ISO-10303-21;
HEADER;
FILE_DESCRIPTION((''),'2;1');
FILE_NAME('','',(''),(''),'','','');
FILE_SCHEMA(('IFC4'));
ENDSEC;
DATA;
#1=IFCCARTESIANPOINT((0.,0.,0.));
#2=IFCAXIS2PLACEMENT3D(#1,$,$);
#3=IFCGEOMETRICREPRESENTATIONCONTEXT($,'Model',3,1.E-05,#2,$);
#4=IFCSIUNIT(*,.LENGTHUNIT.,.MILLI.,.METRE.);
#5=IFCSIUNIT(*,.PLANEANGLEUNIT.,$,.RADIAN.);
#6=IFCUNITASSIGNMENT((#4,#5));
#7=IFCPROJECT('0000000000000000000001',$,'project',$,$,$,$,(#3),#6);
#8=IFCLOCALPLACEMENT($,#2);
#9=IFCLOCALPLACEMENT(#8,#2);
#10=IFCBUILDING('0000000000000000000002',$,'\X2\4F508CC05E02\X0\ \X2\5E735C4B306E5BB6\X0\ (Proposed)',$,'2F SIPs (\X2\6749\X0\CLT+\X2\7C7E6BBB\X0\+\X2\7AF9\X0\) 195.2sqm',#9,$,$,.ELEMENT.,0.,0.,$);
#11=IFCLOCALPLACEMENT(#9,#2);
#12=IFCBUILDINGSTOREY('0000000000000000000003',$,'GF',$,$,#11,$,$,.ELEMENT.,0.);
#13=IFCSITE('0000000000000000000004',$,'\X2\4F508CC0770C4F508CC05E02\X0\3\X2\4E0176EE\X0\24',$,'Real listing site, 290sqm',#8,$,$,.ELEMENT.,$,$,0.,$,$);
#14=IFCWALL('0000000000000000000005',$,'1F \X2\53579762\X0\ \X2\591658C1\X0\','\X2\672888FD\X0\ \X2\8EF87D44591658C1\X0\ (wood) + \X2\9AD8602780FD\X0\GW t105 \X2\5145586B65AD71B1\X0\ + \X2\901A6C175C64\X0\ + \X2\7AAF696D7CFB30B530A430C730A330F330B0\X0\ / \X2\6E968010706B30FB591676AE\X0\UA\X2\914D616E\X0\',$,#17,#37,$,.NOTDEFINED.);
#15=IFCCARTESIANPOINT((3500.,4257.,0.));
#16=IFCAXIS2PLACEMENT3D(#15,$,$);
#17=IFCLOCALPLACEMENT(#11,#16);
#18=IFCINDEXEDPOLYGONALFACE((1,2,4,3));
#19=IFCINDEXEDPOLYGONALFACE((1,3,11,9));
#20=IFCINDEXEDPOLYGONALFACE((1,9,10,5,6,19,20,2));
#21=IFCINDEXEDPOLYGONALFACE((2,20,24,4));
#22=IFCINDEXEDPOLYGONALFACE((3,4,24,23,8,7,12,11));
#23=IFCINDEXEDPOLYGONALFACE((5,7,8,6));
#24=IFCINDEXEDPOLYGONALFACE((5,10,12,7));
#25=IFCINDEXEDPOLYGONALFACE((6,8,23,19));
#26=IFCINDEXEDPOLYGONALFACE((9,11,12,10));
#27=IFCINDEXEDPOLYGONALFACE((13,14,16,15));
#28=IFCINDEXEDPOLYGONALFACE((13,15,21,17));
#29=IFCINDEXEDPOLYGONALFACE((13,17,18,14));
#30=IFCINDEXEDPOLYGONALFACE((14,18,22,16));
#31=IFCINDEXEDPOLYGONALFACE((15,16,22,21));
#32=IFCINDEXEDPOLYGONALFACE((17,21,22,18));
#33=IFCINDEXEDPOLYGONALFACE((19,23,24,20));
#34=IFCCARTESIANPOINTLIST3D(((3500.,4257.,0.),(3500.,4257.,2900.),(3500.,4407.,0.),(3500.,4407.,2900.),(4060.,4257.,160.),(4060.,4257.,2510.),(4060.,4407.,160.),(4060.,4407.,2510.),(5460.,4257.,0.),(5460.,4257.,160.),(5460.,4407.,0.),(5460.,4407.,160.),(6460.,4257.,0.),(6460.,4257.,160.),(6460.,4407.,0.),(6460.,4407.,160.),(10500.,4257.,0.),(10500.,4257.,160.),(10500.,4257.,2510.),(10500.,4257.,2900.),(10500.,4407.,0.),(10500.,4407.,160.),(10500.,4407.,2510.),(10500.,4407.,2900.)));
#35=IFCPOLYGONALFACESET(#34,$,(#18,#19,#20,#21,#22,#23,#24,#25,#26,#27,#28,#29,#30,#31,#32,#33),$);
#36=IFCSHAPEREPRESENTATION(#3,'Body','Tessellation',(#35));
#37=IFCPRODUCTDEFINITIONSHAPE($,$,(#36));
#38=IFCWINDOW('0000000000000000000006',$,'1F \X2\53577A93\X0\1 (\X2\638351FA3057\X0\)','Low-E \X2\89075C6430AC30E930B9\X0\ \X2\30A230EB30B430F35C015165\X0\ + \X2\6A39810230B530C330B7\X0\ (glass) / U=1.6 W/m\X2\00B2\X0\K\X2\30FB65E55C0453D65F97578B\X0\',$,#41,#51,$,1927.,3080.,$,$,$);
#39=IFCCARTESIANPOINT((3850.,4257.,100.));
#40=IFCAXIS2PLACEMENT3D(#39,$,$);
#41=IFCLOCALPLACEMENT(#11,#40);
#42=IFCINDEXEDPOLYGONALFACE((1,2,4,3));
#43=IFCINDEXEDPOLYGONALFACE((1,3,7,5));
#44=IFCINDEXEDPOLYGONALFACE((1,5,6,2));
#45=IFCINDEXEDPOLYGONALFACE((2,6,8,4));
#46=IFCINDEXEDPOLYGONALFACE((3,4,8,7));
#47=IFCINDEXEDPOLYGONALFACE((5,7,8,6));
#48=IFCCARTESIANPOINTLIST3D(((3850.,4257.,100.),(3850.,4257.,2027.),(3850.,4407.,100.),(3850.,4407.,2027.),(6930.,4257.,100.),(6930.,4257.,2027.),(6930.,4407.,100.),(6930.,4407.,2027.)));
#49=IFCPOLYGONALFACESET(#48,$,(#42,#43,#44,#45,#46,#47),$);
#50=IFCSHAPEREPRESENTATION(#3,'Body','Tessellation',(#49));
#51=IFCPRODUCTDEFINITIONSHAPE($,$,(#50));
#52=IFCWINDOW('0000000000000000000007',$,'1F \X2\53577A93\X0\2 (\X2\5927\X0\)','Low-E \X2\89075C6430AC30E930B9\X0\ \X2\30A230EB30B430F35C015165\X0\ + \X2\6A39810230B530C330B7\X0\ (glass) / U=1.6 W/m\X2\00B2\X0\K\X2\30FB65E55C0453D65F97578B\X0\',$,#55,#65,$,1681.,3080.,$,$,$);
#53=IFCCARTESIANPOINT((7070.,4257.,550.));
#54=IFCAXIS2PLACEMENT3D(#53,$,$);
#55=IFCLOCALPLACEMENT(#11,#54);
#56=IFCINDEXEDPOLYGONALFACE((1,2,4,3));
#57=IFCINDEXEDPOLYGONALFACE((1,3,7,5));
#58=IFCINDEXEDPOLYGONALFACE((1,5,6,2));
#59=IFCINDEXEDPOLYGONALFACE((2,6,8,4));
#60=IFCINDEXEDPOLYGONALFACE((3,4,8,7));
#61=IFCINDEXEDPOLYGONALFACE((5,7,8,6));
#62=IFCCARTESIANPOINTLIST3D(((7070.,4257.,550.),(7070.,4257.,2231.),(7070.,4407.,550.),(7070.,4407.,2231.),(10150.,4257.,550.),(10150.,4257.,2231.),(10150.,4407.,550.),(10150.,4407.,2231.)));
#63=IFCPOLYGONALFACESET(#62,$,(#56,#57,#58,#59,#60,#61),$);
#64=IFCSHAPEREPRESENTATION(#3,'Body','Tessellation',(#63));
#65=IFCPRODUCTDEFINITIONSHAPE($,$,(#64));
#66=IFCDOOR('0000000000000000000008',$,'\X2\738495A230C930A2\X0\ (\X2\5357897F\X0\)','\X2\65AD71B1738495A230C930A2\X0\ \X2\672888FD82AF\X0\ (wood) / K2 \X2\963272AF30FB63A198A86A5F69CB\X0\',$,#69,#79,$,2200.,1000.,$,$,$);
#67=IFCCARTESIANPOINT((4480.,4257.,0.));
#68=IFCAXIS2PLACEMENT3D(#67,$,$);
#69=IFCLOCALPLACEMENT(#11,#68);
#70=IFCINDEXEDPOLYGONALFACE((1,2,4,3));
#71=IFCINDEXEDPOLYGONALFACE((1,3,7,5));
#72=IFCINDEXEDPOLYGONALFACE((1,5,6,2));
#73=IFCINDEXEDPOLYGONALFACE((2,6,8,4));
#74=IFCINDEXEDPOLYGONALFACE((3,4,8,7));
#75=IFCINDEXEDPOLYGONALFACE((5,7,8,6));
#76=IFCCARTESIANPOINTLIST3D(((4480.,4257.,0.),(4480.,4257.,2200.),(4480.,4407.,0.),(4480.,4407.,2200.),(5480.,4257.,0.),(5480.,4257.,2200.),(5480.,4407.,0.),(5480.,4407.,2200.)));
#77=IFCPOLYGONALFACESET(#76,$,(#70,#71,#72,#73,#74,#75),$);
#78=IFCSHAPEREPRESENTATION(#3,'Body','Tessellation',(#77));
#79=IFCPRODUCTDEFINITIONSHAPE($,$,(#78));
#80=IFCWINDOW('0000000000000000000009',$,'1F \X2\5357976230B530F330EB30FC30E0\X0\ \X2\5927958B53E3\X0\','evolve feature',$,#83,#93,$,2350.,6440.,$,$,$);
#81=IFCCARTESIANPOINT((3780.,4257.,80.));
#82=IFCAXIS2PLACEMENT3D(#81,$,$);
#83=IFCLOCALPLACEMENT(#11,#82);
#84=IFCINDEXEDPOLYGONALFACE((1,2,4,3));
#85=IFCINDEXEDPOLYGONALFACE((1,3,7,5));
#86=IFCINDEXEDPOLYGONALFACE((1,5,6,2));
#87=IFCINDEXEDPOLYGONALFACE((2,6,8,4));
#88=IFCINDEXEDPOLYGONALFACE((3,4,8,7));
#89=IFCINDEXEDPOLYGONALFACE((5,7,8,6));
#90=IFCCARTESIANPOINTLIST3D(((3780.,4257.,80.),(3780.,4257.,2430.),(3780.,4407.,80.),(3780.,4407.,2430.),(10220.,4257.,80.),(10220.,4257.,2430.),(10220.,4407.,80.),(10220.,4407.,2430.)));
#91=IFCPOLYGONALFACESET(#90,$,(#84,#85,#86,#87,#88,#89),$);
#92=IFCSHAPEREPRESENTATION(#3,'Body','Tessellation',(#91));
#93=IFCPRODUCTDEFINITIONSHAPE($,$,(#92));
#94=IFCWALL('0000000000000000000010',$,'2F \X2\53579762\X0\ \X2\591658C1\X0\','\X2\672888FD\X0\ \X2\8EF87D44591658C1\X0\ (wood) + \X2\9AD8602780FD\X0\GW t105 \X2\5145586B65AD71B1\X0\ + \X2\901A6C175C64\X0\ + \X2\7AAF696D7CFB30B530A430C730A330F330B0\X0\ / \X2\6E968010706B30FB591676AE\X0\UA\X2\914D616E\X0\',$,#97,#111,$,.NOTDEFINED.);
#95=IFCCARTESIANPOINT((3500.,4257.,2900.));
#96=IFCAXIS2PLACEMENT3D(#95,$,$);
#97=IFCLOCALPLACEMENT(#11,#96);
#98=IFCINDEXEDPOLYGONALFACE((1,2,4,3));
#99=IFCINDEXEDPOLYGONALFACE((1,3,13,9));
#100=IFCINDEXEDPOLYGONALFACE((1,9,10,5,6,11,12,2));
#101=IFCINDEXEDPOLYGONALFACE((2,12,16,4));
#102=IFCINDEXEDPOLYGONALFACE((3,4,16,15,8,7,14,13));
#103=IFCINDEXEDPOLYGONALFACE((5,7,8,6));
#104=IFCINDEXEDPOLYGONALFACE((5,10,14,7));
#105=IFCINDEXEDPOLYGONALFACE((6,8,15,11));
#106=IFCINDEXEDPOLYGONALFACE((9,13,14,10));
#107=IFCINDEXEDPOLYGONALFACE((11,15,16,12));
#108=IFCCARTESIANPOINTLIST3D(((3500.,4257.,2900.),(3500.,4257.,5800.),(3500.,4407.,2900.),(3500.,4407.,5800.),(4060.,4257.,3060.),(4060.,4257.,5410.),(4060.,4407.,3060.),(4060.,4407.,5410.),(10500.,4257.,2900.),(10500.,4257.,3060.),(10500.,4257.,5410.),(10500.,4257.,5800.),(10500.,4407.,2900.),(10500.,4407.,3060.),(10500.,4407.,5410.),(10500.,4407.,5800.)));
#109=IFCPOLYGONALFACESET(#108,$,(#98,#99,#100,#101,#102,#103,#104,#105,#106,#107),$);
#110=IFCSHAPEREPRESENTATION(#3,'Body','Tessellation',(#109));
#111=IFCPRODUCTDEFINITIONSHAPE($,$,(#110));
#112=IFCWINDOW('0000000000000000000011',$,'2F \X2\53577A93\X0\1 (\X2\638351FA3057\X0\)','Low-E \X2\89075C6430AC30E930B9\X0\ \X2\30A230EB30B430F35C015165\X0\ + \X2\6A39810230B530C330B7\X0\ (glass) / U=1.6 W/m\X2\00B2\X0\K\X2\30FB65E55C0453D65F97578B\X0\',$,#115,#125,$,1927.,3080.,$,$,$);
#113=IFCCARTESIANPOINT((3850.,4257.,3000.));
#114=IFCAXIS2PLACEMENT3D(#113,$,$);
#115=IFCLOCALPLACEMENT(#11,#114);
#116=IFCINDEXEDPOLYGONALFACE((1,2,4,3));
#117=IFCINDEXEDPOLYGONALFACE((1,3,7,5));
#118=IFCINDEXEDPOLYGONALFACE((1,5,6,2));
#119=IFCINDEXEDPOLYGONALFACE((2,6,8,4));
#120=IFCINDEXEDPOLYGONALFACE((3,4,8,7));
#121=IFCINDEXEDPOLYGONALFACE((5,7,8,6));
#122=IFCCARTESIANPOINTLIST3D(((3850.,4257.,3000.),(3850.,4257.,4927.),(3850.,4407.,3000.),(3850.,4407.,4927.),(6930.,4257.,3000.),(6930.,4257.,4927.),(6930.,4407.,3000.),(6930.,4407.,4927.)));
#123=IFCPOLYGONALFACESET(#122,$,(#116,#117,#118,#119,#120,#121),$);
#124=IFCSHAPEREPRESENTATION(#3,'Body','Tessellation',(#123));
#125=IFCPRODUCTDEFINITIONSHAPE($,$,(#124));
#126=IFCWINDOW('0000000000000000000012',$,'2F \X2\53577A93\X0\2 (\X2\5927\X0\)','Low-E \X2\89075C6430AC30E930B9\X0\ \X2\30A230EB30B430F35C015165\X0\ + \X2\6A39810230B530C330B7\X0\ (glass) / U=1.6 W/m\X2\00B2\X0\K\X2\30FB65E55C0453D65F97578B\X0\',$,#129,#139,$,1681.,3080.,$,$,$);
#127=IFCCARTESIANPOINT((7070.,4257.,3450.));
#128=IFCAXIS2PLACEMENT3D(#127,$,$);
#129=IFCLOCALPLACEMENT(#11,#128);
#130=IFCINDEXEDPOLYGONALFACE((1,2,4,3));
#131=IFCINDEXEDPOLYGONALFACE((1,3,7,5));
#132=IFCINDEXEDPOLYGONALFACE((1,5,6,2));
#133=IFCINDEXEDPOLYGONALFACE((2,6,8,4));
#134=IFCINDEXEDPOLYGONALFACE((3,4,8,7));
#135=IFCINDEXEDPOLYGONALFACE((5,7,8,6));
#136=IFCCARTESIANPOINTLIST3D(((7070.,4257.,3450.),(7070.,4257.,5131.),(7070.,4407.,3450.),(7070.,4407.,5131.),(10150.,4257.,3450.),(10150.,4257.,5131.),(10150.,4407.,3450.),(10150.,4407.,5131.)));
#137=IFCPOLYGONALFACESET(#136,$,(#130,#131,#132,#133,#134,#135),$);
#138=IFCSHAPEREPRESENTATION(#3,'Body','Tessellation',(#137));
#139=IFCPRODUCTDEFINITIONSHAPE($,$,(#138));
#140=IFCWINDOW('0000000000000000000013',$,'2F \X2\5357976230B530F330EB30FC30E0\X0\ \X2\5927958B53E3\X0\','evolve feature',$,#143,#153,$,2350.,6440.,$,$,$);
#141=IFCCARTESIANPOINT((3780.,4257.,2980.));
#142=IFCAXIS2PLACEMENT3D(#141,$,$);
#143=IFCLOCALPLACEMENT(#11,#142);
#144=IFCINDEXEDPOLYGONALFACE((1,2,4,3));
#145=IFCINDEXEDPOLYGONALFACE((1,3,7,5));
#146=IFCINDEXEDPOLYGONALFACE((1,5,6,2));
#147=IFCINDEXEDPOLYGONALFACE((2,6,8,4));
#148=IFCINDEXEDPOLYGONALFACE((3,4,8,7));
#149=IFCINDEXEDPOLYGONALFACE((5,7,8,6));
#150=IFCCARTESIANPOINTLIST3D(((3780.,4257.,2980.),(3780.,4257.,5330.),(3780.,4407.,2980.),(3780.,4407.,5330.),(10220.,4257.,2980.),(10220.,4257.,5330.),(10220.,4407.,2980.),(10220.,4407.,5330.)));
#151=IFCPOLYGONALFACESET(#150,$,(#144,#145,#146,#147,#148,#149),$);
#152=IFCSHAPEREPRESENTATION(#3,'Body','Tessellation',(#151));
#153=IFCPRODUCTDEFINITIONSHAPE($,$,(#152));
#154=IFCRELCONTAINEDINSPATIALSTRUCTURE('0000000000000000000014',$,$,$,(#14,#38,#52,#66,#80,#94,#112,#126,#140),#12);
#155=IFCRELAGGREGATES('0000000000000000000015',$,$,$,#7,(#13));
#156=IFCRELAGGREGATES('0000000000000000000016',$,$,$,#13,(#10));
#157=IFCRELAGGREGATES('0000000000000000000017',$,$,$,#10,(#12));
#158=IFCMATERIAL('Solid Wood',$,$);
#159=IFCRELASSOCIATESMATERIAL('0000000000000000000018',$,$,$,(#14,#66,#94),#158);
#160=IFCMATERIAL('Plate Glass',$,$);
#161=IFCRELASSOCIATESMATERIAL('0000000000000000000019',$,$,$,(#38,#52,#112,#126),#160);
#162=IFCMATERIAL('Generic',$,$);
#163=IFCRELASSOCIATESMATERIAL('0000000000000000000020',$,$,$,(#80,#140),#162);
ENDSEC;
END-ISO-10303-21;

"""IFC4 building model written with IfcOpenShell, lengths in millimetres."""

from ifc_helpers import new_model, si_unit, frame, frame_2d, origin, place, context, project, spatial, rectangle, extrude, material, element, fill, save


model = new_model("IFC4")

# Units and contexts
model_context = context("Model", 3, precision=1e-05, world=origin())
ifc_project = project(units=[si_unit("LENGTHUNIT", "METRE", prefix="MILLI"), si_unit("PLANEANGLEUNIT", "RADIAN")], contexts=[model_context])

# Site, building, storey
site_placement = place(None, origin())
site = spatial("IfcSite", under=ifc_project, at=site_placement, Name="佐賀県佐賀市3丁目24", ObjectType="Real listing site, 290sqm", CompositionType="ELEMENT", RefElevation=0.0)
building_placement = place(site_placement, origin())
building = spatial("IfcBuilding", under=site, at=building_placement, Name="佐賀市 平屋の家 (Proposed)", ObjectType="2F SIPs (杉CLT+籾殻+竹) 195.2sqm", CompositionType="ELEMENT", ElevationOfRefHeight=0.0, ElevationOfTerrain=0.0)
storey_placement = place(building_placement, origin())
storey = spatial("IfcBuildingStorey", under=building, at=storey_placement, Name="GF", CompositionType="ELEMENT", Elevation=0.0)

# Shared definitions
ifc_material_1 = material(Name="Solid Wood")

# Wall, openings, windows, door
wall_1_placement = place(storey_placement, frame((3500.0, 4257.0, 0.0)))
wall_1 = element("IfcWall", 1, at=wall_1_placement, inside=storey, material=ifc_material_1, Name="1F 南面 外壁", Description="木製 軸組外壁 (wood) + 高性能GW t105 充填断熱 + 通気層 + 窯業系サイディング / 準耐火・外皮UA配慮", PredefinedType="NOTDEFINED", context=model_context, shape_type="SweptSolid", body=[
    extrude(rectangle(XDim=7000.0, YDim=150.0, at=frame_2d((3500.0, 75.0))), frame((3500.0, 4257.0, 0.0)), (0.0, 0.0, 1.0), 2900.0),
])
opening_1_placement = place(storey_placement, frame((3850.0, 4257.0, 100.0)))
opening_1 = element("IfcOpeningElement", 2, at=opening_1_placement, cuts=wall_1, PredefinedType="NOTDEFINED", context=model_context, shape_type="SweptSolid", body=[
    extrude(rectangle(XDim=3080.0, YDim=150.0, at=frame_2d((1540.0, 75.0))), frame((3850.0, 4257.0, 100.0)), (0.0, 0.0, 1.0), 1927.0),
])
opening_2_placement = place(storey_placement, frame((7070.0, 4257.0, 550.0)))
opening_2 = element("IfcOpeningElement", 3, at=opening_2_placement, cuts=wall_1, PredefinedType="NOTDEFINED", context=model_context, shape_type="SweptSolid", body=[
    extrude(rectangle(XDim=3080.0, YDim=150.0, at=frame_2d((1540.0, 75.0))), frame((7070.0, 4257.0, 550.0)), (0.0, 0.0, 1.0), 1681.0),
])
opening_3_placement = place(storey_placement, frame((4480.0, 4257.0, 0.0)))
opening_3 = element("IfcOpeningElement", 4, at=opening_3_placement, cuts=wall_1, PredefinedType="NOTDEFINED", context=model_context, shape_type="SweptSolid", body=[
    extrude(rectangle(XDim=1000.0, YDim=150.0, at=frame_2d((500.0, 75.0))), frame((4480.0, 4257.0, 0.0)), (0.0, 0.0, 1.0), 2200.0),
])
opening_4_placement = place(storey_placement, frame((3780.0, 4257.0, 80.0)))
opening_4 = element("IfcOpeningElement", 5, at=opening_4_placement, cuts=wall_1, PredefinedType="NOTDEFINED", context=model_context, shape_type="SweptSolid", body=[
    extrude(rectangle(XDim=6440.0, YDim=150.0, at=frame_2d((3220.0, 75.0))), frame((3780.0, 4257.0, 80.0)), (0.0, 0.0, 1.0), 2350.0),
])
ifc_material_2 = material(Name="Plate Glass")
window_1_placement = place(storey_placement, frame((3850.0, 4257.0, 100.0)))
window_1 = element("IfcWindow", 6, at=window_1_placement, inside=storey, material=ifc_material_2, Name="1F 南窓1 (掃出し)", Description="Low-E 複層ガラス アルゴン封入 + 樹脂サッシ (glass) / U=1.6 W/m²K・日射取得型", OverallHeight=1927.0, OverallWidth=3080.0, context=model_context, shape_type="SweptSolid", body=[
    extrude(rectangle(XDim=3080.0, YDim=150.0, at=frame_2d((1540.0, 75.0))), frame((3850.0, 4257.0, 100.0)), (0.0, 0.0, 1.0), 1927.0),
])
fill(opening_1, window_1)
window_2_placement = place(storey_placement, frame((7070.0, 4257.0, 550.0)))
window_2 = element("IfcWindow", 7, at=window_2_placement, inside=storey, material=ifc_material_2, Name="1F 南窓2 (大)", Description="Low-E 複層ガラス アルゴン封入 + 樹脂サッシ (glass) / U=1.6 W/m²K・日射取得型", OverallHeight=1681.0, OverallWidth=3080.0, context=model_context, shape_type="SweptSolid", body=[
    extrude(rectangle(XDim=3080.0, YDim=150.0, at=frame_2d((1540.0, 75.0))), frame((7070.0, 4257.0, 550.0)), (0.0, 0.0, 1.0), 1681.0),
])
fill(opening_2, window_2)
door_placement = place(storey_placement, frame((4480.0, 4257.0, 0.0)))
door = element("IfcDoor", 8, at=door_placement, inside=storey, material=ifc_material_1, Name="玄関ドア (南西)", Description="断熱玄関ドア 木製芯 (wood) / K2 防犯・採風機構", OverallHeight=2200.0, OverallWidth=1000.0, context=model_context, shape_type="SweptSolid", body=[
    extrude(rectangle(XDim=1000.0, YDim=150.0, at=frame_2d((500.0, 75.0))), frame((4480.0, 4257.0, 0.0)), (0.0, 0.0, 1.0), 2200.0),
])
fill(opening_3, door)
ifc_material_3 = material(Name="Generic")
window_3_placement = place(storey_placement, frame((3780.0, 4257.0, 80.0)))
window_3 = element("IfcWindow", 9, at=window_3_placement, inside=storey, material=ifc_material_3, Name="1F 南面サンルーム 大開口", Description="evolve feature", OverallHeight=2350.0, OverallWidth=6440.0, context=model_context, shape_type="SweptSolid", body=[
    extrude(rectangle(XDim=6440.0, YDim=150.0, at=frame_2d((3220.0, 75.0))), frame((3780.0, 4257.0, 80.0)), (0.0, 0.0, 1.0), 2350.0),
])
fill(opening_4, window_3)

# Wall, openings, windows
wall_2_placement = place(storey_placement, frame((3500.0, 4257.0, 2900.0)))
wall_2 = element("IfcWall", 10, at=wall_2_placement, inside=storey, material=ifc_material_1, Name="2F 南面 外壁", Description="木製 軸組外壁 (wood) + 高性能GW t105 充填断熱 + 通気層 + 窯業系サイディング / 準耐火・外皮UA配慮", PredefinedType="NOTDEFINED", context=model_context, shape_type="SweptSolid", body=[
    extrude(rectangle(XDim=7000.0, YDim=150.0, at=frame_2d((3500.0, 75.0))), frame((3500.0, 4257.0, 2900.0)), (0.0, 0.0, 1.0), 2900.0),
])
opening_5_placement = place(storey_placement, frame((3850.0, 4257.0, 3000.0)))
opening_5 = element("IfcOpeningElement", 11, at=opening_5_placement, cuts=wall_2, PredefinedType="NOTDEFINED", context=model_context, shape_type="SweptSolid", body=[
    extrude(rectangle(XDim=3080.0, YDim=150.0, at=frame_2d((1540.0, 75.0))), frame((3850.0, 4257.0, 3000.0)), (0.0, 0.0, 1.0), 1927.0),
])
opening_6_placement = place(storey_placement, frame((7070.0, 4257.0, 3450.0)))
opening_6 = element("IfcOpeningElement", 12, at=opening_6_placement, cuts=wall_2, PredefinedType="NOTDEFINED", context=model_context, shape_type="SweptSolid", body=[
    extrude(rectangle(XDim=3080.0, YDim=150.0, at=frame_2d((1540.0, 75.0))), frame((7070.0, 4257.0, 3450.0)), (0.0, 0.0, 1.0), 1681.0),
])
opening_7_placement = place(storey_placement, frame((3780.0, 4257.0, 2980.0)))
opening_7 = element("IfcOpeningElement", 13, at=opening_7_placement, cuts=wall_2, PredefinedType="NOTDEFINED", context=model_context, shape_type="SweptSolid", body=[
    extrude(rectangle(XDim=6440.0, YDim=150.0, at=frame_2d((3220.0, 75.0))), frame((3780.0, 4257.0, 2980.0)), (0.0, 0.0, 1.0), 2350.0),
])
window_4_placement = place(storey_placement, frame((3850.0, 4257.0, 3000.0)))
window_4 = element("IfcWindow", 14, at=window_4_placement, inside=storey, material=ifc_material_2, Name="2F 南窓1 (掃出し)", Description="Low-E 複層ガラス アルゴン封入 + 樹脂サッシ (glass) / U=1.6 W/m²K・日射取得型", OverallHeight=1927.0, OverallWidth=3080.0, context=model_context, shape_type="SweptSolid", body=[
    extrude(rectangle(XDim=3080.0, YDim=150.0, at=frame_2d((1540.0, 75.0))), frame((3850.0, 4257.0, 3000.0)), (0.0, 0.0, 1.0), 1927.0),
])
fill(opening_5, window_4)
window_5_placement = place(storey_placement, frame((7070.0, 4257.0, 3450.0)))
window_5 = element("IfcWindow", 15, at=window_5_placement, inside=storey, material=ifc_material_2, Name="2F 南窓2 (大)", Description="Low-E 複層ガラス アルゴン封入 + 樹脂サッシ (glass) / U=1.6 W/m²K・日射取得型", OverallHeight=1681.0, OverallWidth=3080.0, context=model_context, shape_type="SweptSolid", body=[
    extrude(rectangle(XDim=3080.0, YDim=150.0, at=frame_2d((1540.0, 75.0))), frame((7070.0, 4257.0, 3450.0)), (0.0, 0.0, 1.0), 1681.0),
])
fill(opening_6, window_5)
window_6_placement = place(storey_placement, frame((3780.0, 4257.0, 2980.0)))
window_6 = element("IfcWindow", 16, at=window_6_placement, inside=storey, material=ifc_material_3, Name="2F 南面サンルーム 大開口", Description="evolve feature", OverallHeight=2350.0, OverallWidth=6440.0, context=model_context, shape_type="SweptSolid", body=[
    extrude(rectangle(XDim=6440.0, YDim=150.0, at=frame_2d((3220.0, 75.0))), frame((3780.0, 4257.0, 2980.0)), (0.0, 0.0, 1.0), 2350.0),
])
fill(opening_7, window_6)

save(model, "model.ifc")
